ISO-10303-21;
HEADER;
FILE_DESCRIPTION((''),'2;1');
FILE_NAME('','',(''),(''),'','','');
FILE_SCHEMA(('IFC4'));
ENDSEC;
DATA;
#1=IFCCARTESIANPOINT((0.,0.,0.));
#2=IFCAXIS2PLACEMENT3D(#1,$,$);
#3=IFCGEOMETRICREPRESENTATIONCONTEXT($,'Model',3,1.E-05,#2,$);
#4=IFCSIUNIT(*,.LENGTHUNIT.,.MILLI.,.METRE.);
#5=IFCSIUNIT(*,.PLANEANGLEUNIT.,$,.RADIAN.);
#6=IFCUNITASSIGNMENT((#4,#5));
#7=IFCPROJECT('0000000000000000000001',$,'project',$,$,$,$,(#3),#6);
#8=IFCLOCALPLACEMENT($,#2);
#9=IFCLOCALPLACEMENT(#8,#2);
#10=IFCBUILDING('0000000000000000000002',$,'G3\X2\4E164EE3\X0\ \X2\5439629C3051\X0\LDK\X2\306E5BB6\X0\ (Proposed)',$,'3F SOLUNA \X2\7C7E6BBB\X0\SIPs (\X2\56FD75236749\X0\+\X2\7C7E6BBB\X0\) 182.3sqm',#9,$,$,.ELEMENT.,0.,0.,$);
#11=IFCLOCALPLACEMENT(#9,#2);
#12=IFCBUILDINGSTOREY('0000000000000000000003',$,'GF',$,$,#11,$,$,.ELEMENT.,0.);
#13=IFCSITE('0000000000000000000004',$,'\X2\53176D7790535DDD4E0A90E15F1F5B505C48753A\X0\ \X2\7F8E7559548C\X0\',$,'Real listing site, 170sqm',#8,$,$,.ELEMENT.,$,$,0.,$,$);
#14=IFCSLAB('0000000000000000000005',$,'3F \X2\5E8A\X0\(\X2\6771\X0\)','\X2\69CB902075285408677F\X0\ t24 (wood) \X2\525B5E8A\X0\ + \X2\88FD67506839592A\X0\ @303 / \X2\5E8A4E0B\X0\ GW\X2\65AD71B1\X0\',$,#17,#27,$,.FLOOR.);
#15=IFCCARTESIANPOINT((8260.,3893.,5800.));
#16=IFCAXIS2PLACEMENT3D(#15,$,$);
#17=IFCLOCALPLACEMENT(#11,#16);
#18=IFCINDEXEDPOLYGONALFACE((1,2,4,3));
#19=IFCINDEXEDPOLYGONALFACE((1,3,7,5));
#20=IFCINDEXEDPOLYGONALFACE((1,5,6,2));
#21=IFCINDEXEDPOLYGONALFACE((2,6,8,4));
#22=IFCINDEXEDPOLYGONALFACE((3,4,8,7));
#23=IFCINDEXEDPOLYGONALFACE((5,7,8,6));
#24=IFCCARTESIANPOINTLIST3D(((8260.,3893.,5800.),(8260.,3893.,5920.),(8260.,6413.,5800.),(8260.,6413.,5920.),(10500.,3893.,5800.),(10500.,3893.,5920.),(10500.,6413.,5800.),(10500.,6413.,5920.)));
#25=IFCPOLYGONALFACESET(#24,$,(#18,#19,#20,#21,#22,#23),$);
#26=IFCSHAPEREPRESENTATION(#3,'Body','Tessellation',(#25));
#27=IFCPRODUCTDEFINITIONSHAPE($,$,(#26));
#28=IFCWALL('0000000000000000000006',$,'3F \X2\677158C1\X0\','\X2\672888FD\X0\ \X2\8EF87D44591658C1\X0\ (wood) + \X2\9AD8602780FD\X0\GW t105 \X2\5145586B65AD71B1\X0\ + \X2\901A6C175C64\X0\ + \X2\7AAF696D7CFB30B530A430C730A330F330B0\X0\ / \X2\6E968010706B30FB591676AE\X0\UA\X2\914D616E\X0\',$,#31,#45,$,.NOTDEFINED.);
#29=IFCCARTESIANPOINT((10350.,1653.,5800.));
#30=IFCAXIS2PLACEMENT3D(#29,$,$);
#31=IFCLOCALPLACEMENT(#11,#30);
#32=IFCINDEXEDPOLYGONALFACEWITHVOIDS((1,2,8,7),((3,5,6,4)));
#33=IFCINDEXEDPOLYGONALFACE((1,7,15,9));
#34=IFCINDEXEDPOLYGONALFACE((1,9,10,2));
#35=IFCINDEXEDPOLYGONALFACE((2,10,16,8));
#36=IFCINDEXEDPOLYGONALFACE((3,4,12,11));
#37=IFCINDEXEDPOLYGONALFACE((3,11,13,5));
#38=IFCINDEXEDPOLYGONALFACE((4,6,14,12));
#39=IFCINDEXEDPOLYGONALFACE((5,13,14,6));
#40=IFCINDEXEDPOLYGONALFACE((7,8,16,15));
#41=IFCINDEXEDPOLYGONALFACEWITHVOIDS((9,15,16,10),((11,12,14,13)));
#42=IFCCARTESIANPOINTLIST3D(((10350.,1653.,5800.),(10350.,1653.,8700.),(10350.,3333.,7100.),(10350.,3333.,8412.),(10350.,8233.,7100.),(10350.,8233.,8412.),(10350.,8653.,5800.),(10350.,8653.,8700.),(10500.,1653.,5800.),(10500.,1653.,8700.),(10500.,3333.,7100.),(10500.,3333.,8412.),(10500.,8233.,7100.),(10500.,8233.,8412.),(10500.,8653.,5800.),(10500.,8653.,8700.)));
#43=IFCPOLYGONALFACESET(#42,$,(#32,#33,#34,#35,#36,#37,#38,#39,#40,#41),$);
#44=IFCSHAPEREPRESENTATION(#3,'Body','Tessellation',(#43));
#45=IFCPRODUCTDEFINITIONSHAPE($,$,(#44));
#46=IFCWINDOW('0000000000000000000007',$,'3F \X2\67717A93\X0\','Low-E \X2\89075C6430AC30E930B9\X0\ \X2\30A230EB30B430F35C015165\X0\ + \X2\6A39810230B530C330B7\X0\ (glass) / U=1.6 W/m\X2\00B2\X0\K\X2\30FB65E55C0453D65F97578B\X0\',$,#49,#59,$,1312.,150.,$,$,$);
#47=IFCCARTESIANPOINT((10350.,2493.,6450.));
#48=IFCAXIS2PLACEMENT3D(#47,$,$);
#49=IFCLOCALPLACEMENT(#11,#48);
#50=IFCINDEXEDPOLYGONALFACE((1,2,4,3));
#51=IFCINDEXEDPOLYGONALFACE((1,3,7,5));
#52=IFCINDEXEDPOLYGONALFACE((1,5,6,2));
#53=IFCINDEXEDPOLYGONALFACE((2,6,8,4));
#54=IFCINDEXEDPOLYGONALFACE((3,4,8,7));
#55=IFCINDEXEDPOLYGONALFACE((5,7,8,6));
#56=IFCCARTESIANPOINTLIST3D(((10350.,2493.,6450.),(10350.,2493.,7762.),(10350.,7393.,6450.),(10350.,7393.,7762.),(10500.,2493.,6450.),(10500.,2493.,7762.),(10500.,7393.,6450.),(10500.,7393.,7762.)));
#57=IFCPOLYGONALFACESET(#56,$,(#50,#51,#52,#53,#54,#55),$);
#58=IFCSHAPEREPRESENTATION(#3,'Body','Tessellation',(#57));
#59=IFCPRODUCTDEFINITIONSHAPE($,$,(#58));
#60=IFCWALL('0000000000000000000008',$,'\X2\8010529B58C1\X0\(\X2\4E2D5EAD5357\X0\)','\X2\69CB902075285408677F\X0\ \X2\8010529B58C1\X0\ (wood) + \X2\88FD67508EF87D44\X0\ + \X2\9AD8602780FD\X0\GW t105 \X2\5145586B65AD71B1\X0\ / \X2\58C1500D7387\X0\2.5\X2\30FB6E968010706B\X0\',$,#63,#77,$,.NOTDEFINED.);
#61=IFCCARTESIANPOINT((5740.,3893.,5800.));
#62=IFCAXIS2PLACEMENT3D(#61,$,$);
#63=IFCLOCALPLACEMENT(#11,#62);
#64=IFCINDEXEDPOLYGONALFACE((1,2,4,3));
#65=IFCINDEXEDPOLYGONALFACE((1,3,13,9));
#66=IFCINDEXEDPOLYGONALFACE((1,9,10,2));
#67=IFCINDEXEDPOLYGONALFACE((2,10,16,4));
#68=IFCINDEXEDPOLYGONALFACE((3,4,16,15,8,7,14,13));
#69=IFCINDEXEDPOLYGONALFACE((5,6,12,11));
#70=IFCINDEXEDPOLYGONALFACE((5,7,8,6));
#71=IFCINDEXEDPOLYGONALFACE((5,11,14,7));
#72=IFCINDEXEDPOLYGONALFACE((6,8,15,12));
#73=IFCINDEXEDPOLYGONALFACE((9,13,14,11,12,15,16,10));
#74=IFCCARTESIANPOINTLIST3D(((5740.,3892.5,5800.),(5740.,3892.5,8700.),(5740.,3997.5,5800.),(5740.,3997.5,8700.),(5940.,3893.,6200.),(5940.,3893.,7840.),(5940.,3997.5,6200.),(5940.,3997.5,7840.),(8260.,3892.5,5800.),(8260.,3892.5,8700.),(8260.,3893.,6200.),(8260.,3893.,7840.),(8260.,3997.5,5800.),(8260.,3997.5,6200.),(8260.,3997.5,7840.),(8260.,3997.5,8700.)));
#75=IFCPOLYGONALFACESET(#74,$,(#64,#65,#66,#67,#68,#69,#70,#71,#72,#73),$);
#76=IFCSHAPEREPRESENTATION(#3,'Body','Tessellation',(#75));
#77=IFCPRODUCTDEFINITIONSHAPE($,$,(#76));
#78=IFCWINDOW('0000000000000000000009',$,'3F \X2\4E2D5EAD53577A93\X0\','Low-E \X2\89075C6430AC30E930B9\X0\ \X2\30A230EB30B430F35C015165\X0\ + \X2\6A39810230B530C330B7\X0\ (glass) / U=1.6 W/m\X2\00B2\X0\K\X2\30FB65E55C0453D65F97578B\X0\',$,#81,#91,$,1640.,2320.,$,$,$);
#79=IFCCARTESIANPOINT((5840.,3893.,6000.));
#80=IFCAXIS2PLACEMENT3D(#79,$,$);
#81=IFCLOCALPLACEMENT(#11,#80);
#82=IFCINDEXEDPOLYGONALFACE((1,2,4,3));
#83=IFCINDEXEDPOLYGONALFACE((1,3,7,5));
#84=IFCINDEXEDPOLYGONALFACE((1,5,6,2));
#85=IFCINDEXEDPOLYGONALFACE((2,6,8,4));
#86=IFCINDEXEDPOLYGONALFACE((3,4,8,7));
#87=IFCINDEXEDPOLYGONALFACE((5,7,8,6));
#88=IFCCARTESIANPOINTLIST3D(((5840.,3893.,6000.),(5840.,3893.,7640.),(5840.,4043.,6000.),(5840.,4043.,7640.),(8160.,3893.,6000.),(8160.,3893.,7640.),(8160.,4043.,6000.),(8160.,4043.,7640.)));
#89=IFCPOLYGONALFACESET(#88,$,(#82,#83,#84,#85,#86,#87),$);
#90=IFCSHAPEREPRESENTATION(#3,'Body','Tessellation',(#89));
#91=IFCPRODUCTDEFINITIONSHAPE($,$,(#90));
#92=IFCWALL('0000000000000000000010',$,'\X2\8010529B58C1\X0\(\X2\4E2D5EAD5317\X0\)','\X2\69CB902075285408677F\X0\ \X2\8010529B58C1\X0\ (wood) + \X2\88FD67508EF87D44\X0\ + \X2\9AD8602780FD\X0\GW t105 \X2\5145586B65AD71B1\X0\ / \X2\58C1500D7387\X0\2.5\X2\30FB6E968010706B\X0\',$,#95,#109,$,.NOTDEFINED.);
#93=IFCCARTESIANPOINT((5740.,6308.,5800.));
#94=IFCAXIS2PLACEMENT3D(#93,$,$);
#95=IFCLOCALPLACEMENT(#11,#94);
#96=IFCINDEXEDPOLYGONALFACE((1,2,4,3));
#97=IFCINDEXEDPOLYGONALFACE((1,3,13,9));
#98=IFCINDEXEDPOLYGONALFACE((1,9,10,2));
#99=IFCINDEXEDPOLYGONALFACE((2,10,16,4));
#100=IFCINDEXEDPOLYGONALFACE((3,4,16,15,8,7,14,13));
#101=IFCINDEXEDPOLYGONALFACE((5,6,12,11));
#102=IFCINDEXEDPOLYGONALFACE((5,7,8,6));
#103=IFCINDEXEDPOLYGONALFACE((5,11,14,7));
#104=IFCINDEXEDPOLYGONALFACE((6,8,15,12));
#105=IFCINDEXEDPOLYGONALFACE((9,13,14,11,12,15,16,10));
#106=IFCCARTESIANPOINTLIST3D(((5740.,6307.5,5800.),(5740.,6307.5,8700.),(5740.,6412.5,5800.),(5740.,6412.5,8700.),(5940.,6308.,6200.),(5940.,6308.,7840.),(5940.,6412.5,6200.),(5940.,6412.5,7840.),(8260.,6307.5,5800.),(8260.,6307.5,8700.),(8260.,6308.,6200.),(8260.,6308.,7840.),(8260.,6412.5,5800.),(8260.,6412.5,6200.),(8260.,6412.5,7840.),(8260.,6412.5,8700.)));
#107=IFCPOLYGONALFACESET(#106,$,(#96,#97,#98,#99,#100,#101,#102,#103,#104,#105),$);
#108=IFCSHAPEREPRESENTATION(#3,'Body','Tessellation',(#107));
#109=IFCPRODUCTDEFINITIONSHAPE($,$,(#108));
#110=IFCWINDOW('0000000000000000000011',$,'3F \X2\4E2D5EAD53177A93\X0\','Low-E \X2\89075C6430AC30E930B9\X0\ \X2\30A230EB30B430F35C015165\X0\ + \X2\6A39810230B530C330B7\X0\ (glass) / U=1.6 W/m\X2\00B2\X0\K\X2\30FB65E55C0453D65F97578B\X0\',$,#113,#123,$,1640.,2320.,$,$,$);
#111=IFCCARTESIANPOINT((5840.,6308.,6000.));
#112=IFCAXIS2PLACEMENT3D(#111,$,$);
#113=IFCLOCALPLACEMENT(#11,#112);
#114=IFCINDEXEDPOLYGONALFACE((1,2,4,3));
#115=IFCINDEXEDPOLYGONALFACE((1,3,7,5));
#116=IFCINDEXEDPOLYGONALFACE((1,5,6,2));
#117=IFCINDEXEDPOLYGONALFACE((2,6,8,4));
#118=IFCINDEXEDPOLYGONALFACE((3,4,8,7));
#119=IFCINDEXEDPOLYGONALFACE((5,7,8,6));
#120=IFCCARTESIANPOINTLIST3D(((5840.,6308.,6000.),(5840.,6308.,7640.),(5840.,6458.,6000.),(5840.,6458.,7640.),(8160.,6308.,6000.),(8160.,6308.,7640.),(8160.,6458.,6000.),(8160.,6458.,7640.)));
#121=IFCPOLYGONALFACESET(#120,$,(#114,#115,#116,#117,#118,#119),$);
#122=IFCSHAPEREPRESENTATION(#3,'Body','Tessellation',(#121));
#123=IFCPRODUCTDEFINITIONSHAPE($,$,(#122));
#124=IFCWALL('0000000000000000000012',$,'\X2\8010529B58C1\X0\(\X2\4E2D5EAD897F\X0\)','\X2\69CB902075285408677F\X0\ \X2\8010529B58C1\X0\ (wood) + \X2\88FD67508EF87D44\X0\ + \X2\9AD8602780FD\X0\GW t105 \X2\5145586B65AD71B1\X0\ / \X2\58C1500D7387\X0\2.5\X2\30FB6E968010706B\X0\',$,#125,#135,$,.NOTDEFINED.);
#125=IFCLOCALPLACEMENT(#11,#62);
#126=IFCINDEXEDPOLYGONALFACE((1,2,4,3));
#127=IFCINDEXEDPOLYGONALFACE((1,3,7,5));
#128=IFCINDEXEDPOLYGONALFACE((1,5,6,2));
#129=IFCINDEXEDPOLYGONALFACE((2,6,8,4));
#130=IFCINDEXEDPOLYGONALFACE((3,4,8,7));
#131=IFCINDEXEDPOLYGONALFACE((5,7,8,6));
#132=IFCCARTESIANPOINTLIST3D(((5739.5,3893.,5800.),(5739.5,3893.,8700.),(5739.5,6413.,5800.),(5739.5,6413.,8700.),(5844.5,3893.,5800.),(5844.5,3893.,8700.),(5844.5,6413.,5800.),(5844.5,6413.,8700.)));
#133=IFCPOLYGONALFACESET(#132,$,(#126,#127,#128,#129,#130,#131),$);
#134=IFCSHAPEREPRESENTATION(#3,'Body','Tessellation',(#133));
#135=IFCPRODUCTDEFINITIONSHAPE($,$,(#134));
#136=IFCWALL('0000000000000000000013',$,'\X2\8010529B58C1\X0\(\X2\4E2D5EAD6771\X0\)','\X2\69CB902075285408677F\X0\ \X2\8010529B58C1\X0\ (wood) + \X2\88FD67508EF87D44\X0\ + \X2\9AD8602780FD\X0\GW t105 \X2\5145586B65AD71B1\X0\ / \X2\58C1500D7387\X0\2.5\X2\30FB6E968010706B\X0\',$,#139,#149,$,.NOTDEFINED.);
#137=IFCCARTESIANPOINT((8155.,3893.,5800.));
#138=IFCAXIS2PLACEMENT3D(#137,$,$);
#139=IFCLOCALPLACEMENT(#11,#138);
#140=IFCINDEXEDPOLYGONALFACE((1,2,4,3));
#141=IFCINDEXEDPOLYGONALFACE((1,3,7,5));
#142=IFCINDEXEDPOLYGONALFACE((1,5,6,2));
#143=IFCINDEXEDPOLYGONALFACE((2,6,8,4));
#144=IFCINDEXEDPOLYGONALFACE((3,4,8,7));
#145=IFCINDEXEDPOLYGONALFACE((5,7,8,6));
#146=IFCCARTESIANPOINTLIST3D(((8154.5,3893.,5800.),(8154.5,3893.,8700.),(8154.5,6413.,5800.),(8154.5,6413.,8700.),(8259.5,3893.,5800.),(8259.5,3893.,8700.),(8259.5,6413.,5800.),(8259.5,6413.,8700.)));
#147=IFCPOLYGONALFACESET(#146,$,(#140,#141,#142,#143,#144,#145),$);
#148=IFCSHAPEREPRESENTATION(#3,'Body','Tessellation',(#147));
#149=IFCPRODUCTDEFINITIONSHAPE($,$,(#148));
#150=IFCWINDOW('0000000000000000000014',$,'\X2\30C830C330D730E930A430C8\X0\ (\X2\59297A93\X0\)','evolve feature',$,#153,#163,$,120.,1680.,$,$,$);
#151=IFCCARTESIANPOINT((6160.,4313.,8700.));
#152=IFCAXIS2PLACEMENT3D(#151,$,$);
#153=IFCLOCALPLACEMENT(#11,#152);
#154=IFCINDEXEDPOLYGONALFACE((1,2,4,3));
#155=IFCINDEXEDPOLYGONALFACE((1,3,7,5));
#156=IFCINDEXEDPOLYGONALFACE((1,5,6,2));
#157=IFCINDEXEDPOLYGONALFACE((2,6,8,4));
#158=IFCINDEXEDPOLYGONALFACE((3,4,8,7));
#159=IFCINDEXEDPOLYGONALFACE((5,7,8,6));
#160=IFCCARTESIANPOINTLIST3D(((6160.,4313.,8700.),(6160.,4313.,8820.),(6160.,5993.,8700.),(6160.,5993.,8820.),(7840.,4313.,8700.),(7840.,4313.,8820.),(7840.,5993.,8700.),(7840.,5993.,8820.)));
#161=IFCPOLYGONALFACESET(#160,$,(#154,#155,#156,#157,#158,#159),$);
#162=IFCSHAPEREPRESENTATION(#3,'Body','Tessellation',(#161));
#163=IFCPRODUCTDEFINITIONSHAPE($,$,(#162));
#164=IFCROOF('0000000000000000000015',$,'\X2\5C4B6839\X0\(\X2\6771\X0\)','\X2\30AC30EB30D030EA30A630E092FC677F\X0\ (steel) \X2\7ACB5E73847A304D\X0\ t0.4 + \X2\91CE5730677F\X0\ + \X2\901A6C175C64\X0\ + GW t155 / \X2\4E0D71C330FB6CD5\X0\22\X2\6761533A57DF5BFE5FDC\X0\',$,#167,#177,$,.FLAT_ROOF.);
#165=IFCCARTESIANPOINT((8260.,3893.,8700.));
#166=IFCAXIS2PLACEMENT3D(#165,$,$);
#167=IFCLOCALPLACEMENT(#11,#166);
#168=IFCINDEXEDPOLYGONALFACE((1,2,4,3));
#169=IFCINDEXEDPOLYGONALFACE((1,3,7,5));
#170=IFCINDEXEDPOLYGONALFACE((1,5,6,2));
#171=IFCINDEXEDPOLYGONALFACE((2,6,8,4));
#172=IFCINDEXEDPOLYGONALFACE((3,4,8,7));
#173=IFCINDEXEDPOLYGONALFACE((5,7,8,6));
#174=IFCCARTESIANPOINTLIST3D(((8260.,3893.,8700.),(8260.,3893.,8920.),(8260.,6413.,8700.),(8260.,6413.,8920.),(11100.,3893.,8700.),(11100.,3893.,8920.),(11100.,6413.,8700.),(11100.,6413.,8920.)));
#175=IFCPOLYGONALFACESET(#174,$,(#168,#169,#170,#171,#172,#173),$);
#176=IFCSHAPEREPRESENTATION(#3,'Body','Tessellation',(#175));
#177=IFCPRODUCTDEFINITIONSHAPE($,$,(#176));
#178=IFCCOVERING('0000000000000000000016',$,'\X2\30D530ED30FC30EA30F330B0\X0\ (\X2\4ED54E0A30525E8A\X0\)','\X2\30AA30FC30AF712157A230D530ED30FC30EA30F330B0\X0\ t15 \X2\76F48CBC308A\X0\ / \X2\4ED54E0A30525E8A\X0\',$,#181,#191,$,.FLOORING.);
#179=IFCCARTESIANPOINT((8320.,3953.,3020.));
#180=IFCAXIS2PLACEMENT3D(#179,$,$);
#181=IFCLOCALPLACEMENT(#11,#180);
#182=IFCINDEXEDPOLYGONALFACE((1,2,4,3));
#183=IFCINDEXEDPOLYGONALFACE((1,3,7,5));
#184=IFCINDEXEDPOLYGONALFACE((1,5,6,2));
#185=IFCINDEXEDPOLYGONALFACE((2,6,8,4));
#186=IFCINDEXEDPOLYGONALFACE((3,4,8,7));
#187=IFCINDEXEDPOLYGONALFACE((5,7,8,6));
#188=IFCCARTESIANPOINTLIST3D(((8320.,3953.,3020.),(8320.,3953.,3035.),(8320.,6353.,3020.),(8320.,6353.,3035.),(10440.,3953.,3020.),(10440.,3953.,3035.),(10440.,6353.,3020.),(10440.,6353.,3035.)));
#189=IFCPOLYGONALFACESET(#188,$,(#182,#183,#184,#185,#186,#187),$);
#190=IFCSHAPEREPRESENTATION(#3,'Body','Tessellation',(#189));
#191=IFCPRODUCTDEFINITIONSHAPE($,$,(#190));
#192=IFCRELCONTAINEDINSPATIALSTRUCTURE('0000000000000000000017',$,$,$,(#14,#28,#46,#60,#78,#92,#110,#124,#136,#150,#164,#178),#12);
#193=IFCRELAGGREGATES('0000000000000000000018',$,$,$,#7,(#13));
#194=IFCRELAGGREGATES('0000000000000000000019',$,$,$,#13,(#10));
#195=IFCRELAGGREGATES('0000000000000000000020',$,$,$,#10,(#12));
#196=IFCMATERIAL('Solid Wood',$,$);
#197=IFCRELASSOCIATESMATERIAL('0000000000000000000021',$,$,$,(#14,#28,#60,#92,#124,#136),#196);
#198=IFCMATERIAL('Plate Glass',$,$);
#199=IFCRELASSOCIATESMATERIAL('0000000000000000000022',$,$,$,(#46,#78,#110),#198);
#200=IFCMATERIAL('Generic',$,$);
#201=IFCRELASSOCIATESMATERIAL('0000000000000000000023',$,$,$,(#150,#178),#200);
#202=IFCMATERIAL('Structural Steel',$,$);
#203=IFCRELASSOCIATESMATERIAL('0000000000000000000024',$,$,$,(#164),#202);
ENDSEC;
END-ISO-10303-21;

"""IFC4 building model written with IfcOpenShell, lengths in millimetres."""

from ifc_helpers import new_model, si_unit, frame, frame_2d, origin, place, context, project, spatial, rectangle, extrude, material, element, fill, save


model = new_model("IFC4")

# Units and contexts
model_context = context("Model", 3, precision=1e-05, world=origin())
ifc_project = project(units=[si_unit("LENGTHUNIT", "METRE", prefix="MILLI"), si_unit("PLANEANGLEUNIT", "RADIAN")], contexts=[model_context])

# Site, building, storey
site_placement = place(None, origin())
site = spatial("IfcSite", under=ifc_project, at=site_placement, Name="北海道川上郡弟子屈町 美留和", ObjectType="Real listing site, 170sqm", CompositionType="ELEMENT", RefElevation=0.0)
building_placement = place(site_placement, origin())
building = spatial("IfcBuilding", under=site, at=building_placement, Name="G3世代 吹抜けLDKの家 (Proposed)", ObjectType="3F SOLUNA 籾殻SIPs (国産杉+籾殻) 182.3sqm", CompositionType="ELEMENT", ElevationOfRefHeight=0.0, ElevationOfTerrain=0.0)
storey_placement = place(building_placement, origin())
storey = spatial("IfcBuildingStorey", under=building, at=storey_placement, Name="GF", CompositionType="ELEMENT", Elevation=0.0)

# Slab
ifc_material_1 = material(Name="Solid Wood")
slab_placement = place(storey_placement, frame((8260.0, 3893.0, 5800.0)))
element("IfcSlab", 1, at=slab_placement, inside=storey, material=ifc_material_1, Name="3F 床(東)", Description="構造用合板 t24 (wood) 剛床 + 製材根太 @303 / 床下 GW断熱", PredefinedType="FLOOR", context=model_context, shape_type="SweptSolid", body=[
    extrude(rectangle(XDim=2240.0, YDim=2520.0, at=frame_2d((1120.0, 1260.0))), frame((8260.0, 3893.0, 5800.0)), (0.0, 0.0, 1.0), 120.0),
])

# Walls, openings, windows
wall_1_placement = place(storey_placement, frame((10350.0, 1653.0, 5800.0)))
wall_1 = element("IfcWall", 2, at=wall_1_placement, inside=storey, material=ifc_material_1, Name="3F 東壁", Description="木製 軸組外壁 (wood) + 高性能GW t105 充填断熱 + 通気層 + 窯業系サイディング / 準耐火・外皮UA配慮", PredefinedType="NOTDEFINED", context=model_context, shape_type="SweptSolid", body=[
    extrude(rectangle(XDim=150.0, YDim=7000.0, at=frame_2d((75.0, 3500.0))), frame((10350.0, 1653.0, 5800.0)), (0.0, 0.0, 1.0), 2900.0),
])
opening_1_placement = place(storey_placement, frame((10350.0, 2493.0, 6450.0)))
opening_1 = element("IfcOpeningElement", 3, at=opening_1_placement, cuts=wall_1, PredefinedType="NOTDEFINED", context=model_context, shape_type="SweptSolid", body=[
    extrude(rectangle(XDim=150.0, YDim=4900.0, at=frame_2d((75.0, 2450.0))), frame((10350.0, 2493.0, 6450.0)), (0.0, 0.0, 1.0), 1312.0),
])
ifc_material_2 = material(Name="Plate Glass")
window_1_placement = place(storey_placement, frame((10350.0, 2493.0, 6450.0)))
window_1 = element("IfcWindow", 4, at=window_1_placement, inside=storey, material=ifc_material_2, Name="3F 東窓", Description="Low-E 複層ガラス アルゴン封入 + 樹脂サッシ (glass) / U=1.6 W/m²K・日射取得型", OverallHeight=1312.0, OverallWidth=150.0, context=model_context, shape_type="SweptSolid", body=[
    extrude(rectangle(XDim=150.0, YDim=4900.0, at=frame_2d((75.0, 2450.0))), frame((10350.0, 2493.0, 6450.0)), (0.0, 0.0, 1.0), 1312.0),
])
fill(opening_1, window_1)
wall_2_placement = place(storey_placement, frame((5740.0, 3893.0, 5800.0)))
wall_2 = element("IfcWall", 5, at=wall_2_placement, inside=storey, material=ifc_material_1, Name="耐力壁(中庭南)", Description="構造用合板 耐力壁 (wood) + 製材軸組 + 高性能GW t105 充填断熱 / 壁倍率2.5・準耐火", PredefinedType="NOTDEFINED", context=model_context, shape_type="SweptSolid", body=[
    extrude(rectangle(XDim=2520.0, YDim=105.0, at=frame_2d((1260.0, 52.0))), frame((5740.0, 3893.0, 5800.0)), (0.0, 0.0, 1.0), 2900.0),
])
opening_2_placement = place(storey_placement, frame((5840.0, 3893.0, 6000.0)))
opening_2 = element("IfcOpeningElement", 6, at=opening_2_placement, cuts=wall_2, PredefinedType="NOTDEFINED", context=model_context, shape_type="SweptSolid", body=[
    extrude(rectangle(XDim=2320.0, YDim=150.0, at=frame_2d((1160.0, 75.0))), frame((5840.0, 3893.0, 6000.0)), (0.0, 0.0, 1.0), 1640.0),
])
window_2_placement = place(storey_placement, frame((5840.0, 3893.0, 6000.0)))
window_2 = element("IfcWindow", 7, at=window_2_placement, inside=storey, material=ifc_material_2, Name="3F 中庭南窓", Description="Low-E 複層ガラス アルゴン封入 + 樹脂サッシ (glass) / U=1.6 W/m²K・日射取得型", OverallHeight=1640.0, OverallWidth=2320.0, context=model_context, shape_type="SweptSolid", body=[
    extrude(rectangle(XDim=2320.0, YDim=150.0, at=frame_2d((1160.0, 75.0))), frame((5840.0, 3893.0, 6000.0)), (0.0, 0.0, 1.0), 1640.0),
])
fill(opening_2, window_2)
wall_3_placement = place(storey_placement, frame((5740.0, 6308.0, 5800.0)))
wall_3 = element("IfcWall", 8, at=wall_3_placement, inside=storey, material=ifc_material_1, Name="耐力壁(中庭北)", Description="構造用合板 耐力壁 (wood) + 製材軸組 + 高性能GW t105 充填断熱 / 壁倍率2.5・準耐火", PredefinedType="NOTDEFINED", context=model_context, shape_type="SweptSolid", body=[
    extrude(rectangle(XDim=2520.0, YDim=105.0, at=frame_2d((1260.0, 52.0))), frame((5740.0, 6308.0, 5800.0)), (0.0, 0.0, 1.0), 2900.0),
])
opening_3_placement = place(storey_placement, frame((5840.0, 6308.0, 6000.0)))
opening_3 = element("IfcOpeningElement", 9, at=opening_3_placement, cuts=wall_3, PredefinedType="NOTDEFINED", context=model_context, shape_type="SweptSolid", body=[
    extrude(rectangle(XDim=2320.0, YDim=150.0, at=frame_2d((1160.0, 75.0))), frame((5840.0, 6308.0, 6000.0)), (0.0, 0.0, 1.0), 1640.0),
])
window_3_placement = place(storey_placement, frame((5840.0, 6308.0, 6000.0)))
window_3 = element("IfcWindow", 10, at=window_3_placement, inside=storey, material=ifc_material_2, Name="3F 中庭北窓", Description="Low-E 複層ガラス アルゴン封入 + 樹脂サッシ (glass) / U=1.6 W/m²K・日射取得型", OverallHeight=1640.0, OverallWidth=2320.0, context=model_context, shape_type="SweptSolid", body=[
    extrude(rectangle(XDim=2320.0, YDim=150.0, at=frame_2d((1160.0, 75.0))), frame((5840.0, 6308.0, 6000.0)), (0.0, 0.0, 1.0), 1640.0),
])
fill(opening_3, window_3)

# Walls
wall_4_placement = place(storey_placement, frame((5740.0, 3893.0, 5800.0)))
element("IfcWall", 11, at=wall_4_placement, inside=storey, material=ifc_material_1, Name="耐力壁(中庭西)", Description="構造用合板 耐力壁 (wood) + 製材軸組 + 高性能GW t105 充填断熱 / 壁倍率2.5・準耐火", PredefinedType="NOTDEFINED", context=model_context, shape_type="SweptSolid", body=[
    extrude(rectangle(XDim=105.0, YDim=2520.0, at=frame_2d((52.0, 1260.0))), frame((5740.0, 3893.0, 5800.0)), (0.0, 0.0, 1.0), 2900.0),
])
wall_5_placement = place(storey_placement, frame((8155.0, 3893.0, 5800.0)))
element("IfcWall", 12, at=wall_5_placement, inside=storey, material=ifc_material_1, Name="耐力壁(中庭東)", Description="構造用合板 耐力壁 (wood) + 製材軸組 + 高性能GW t105 充填断熱 / 壁倍率2.5・準耐火", PredefinedType="NOTDEFINED", context=model_context, shape_type="SweptSolid", body=[
    extrude(rectangle(XDim=105.0, YDim=2520.0, at=frame_2d((52.0, 1260.0))), frame((8155.0, 3893.0, 5800.0)), (0.0, 0.0, 1.0), 2900.0),
])

# Window
ifc_material_3 = material(Name="Generic")
window_4_placement = place(storey_placement, frame((6160.0, 4313.0, 8700.0)))
element("IfcWindow", 13, at=window_4_placement, inside=storey, material=ifc_material_3, Name="トップライト (天窓)", Description="evolve feature", OverallHeight=120.0, OverallWidth=1680.0, context=model_context, shape_type="SweptSolid", body=[
    extrude(rectangle(XDim=1680.0, YDim=1680.0, at=frame_2d((840.0, 840.0))), frame((6160.0, 4313.0, 8700.0)), (0.0, 0.0, 1.0), 120.0),
])

# Roof
ifc_material_4 = material(Name="Structural Steel")
for number, where, name in (
    (14, (8260.0, 3893.0, 8700.0), "屋根(東)"),
):
    element("IfcRoof", number, at=place(storey_placement, frame(where)), inside=storey, material=ifc_material_4, Name=name, Description="ガルバリウム鋼板 (steel) 立平葺き t0.4 + 野地板 + 通気層 + GW t155 / 不燃・法22条区域対応", PredefinedType="FLAT_ROOF", context=model_context, shape_type="SweptSolid", body=[
        extrude(rectangle(XDim=2840.0, YDim=2520.0, at=frame_2d((1420.0, 1260.0))), frame((8260.0, 3893.0, 8700.0)), (0.0, 0.0, 1.0), 220.0),
    ])

# Covering
covering_1_placement = place(storey_placement, frame((8320.0, 3953.0, 3020.0)))
element("IfcCovering", 15, at=covering_1_placement, inside=storey, material=ifc_material_3, Name="フローリング (仕上げ床)", Description="オーク無垢フローリング t15 直貼り / 仕上げ床", PredefinedType="FLOORING", context=model_context, shape_type="SweptSolid", body=[
    extrude(rectangle(XDim=2120.0, YDim=2400.0, at=frame_2d((1060.0, 1200.0))), frame((8320.0, 3953.0, 3020.0)), (0.0, 0.0, 1.0), 15.0),
])

save(model, "model.ifc")
